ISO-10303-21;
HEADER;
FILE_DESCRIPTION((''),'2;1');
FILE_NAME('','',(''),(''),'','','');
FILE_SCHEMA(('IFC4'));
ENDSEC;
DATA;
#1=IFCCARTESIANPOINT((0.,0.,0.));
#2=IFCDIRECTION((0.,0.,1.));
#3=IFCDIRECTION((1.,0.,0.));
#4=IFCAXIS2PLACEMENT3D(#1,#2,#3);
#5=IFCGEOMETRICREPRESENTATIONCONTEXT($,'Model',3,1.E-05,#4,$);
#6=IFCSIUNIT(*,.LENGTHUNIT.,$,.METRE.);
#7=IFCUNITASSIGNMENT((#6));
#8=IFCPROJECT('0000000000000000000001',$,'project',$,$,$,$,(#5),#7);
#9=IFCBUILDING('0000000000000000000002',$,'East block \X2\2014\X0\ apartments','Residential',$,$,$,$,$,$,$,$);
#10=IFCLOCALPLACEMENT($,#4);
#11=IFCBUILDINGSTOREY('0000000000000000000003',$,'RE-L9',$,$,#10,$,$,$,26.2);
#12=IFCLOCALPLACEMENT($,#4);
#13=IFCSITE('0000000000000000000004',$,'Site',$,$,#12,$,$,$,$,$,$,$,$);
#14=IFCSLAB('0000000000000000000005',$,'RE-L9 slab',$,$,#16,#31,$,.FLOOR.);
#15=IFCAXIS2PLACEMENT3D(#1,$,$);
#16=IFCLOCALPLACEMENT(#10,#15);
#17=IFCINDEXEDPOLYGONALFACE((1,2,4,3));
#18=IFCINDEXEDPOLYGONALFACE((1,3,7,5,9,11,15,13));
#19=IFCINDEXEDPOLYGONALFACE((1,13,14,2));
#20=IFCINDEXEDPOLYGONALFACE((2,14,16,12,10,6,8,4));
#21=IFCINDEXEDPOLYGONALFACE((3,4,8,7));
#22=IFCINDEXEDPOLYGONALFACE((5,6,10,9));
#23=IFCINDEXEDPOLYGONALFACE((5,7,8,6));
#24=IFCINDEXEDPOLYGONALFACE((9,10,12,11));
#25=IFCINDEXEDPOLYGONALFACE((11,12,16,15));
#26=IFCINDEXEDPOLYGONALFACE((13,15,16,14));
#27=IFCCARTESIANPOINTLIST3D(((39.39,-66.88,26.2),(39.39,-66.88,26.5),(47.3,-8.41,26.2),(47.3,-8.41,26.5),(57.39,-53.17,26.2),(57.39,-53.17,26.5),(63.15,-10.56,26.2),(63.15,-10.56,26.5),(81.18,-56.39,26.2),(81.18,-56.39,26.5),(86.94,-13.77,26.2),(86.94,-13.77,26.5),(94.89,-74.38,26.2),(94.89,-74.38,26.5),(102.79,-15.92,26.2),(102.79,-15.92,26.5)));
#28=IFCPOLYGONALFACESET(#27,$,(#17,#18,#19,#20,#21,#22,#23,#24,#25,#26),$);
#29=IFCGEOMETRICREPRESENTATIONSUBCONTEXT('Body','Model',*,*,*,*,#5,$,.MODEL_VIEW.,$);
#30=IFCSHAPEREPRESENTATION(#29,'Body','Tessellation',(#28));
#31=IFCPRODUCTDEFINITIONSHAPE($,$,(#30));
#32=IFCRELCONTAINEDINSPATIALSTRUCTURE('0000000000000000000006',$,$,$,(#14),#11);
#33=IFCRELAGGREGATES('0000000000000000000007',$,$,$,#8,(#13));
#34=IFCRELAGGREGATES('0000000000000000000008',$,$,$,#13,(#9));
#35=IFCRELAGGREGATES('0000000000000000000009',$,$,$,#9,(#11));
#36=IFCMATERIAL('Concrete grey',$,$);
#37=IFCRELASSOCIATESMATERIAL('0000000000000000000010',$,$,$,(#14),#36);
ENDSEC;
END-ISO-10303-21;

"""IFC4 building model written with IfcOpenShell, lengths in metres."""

from ifc_helpers import new_model, si_unit, frame, origin_with_axes, place, context, subcontext, project, spatial, polyline, outline, extrude, material, element, save


model = new_model("IFC4")

# Units and contexts
model_context = context("Model", 3, precision=1e-05, world=origin_with_axes())
body_context = subcontext(model_context, "Body", "Model", "MODEL_VIEW")
ifc_project = project(units=[si_unit("LENGTHUNIT", "METRE")], contexts=[model_context])

# Site, building, storey
site_placement = place(None, origin_with_axes())
site = spatial("IfcSite", under=ifc_project, at=site_placement, Name="Site")
building = spatial("IfcBuilding", under=site, Name="East block — apartments", Description="Residential")
storey_placement = place(None, origin_with_axes())
storey = spatial("IfcBuildingStorey", under=building, at=storey_placement, Name="RE-L9", Elevation=26.2)

# Slab
ifc_material = material(Name="Concrete grey")
slab_placement = place(storey_placement, origin_with_axes())
element("IfcSlab", 1, at=slab_placement, inside=storey, material=ifc_material, Name="RE-L9 slab", PredefinedType="FLOOR", context=body_context, shape_type="SweptSolid", body=[
    extrude(outline(polyline([(39.39, -66.88), (94.89, -74.38), (102.79, -15.92), (86.94, -13.77), (81.18, -56.39), (57.39, -53.17), (63.15, -10.56), (47.3, -8.41), (39.39, -66.88)])), frame((0.0, 0.0, 26.2), z_axis=(0.0, 0.0, 1.0), x_axis=(1.0, 0.0, 0.0)), (0.0, 0.0, 1.0), 0.3),
])

save(model, "model.ifc")
